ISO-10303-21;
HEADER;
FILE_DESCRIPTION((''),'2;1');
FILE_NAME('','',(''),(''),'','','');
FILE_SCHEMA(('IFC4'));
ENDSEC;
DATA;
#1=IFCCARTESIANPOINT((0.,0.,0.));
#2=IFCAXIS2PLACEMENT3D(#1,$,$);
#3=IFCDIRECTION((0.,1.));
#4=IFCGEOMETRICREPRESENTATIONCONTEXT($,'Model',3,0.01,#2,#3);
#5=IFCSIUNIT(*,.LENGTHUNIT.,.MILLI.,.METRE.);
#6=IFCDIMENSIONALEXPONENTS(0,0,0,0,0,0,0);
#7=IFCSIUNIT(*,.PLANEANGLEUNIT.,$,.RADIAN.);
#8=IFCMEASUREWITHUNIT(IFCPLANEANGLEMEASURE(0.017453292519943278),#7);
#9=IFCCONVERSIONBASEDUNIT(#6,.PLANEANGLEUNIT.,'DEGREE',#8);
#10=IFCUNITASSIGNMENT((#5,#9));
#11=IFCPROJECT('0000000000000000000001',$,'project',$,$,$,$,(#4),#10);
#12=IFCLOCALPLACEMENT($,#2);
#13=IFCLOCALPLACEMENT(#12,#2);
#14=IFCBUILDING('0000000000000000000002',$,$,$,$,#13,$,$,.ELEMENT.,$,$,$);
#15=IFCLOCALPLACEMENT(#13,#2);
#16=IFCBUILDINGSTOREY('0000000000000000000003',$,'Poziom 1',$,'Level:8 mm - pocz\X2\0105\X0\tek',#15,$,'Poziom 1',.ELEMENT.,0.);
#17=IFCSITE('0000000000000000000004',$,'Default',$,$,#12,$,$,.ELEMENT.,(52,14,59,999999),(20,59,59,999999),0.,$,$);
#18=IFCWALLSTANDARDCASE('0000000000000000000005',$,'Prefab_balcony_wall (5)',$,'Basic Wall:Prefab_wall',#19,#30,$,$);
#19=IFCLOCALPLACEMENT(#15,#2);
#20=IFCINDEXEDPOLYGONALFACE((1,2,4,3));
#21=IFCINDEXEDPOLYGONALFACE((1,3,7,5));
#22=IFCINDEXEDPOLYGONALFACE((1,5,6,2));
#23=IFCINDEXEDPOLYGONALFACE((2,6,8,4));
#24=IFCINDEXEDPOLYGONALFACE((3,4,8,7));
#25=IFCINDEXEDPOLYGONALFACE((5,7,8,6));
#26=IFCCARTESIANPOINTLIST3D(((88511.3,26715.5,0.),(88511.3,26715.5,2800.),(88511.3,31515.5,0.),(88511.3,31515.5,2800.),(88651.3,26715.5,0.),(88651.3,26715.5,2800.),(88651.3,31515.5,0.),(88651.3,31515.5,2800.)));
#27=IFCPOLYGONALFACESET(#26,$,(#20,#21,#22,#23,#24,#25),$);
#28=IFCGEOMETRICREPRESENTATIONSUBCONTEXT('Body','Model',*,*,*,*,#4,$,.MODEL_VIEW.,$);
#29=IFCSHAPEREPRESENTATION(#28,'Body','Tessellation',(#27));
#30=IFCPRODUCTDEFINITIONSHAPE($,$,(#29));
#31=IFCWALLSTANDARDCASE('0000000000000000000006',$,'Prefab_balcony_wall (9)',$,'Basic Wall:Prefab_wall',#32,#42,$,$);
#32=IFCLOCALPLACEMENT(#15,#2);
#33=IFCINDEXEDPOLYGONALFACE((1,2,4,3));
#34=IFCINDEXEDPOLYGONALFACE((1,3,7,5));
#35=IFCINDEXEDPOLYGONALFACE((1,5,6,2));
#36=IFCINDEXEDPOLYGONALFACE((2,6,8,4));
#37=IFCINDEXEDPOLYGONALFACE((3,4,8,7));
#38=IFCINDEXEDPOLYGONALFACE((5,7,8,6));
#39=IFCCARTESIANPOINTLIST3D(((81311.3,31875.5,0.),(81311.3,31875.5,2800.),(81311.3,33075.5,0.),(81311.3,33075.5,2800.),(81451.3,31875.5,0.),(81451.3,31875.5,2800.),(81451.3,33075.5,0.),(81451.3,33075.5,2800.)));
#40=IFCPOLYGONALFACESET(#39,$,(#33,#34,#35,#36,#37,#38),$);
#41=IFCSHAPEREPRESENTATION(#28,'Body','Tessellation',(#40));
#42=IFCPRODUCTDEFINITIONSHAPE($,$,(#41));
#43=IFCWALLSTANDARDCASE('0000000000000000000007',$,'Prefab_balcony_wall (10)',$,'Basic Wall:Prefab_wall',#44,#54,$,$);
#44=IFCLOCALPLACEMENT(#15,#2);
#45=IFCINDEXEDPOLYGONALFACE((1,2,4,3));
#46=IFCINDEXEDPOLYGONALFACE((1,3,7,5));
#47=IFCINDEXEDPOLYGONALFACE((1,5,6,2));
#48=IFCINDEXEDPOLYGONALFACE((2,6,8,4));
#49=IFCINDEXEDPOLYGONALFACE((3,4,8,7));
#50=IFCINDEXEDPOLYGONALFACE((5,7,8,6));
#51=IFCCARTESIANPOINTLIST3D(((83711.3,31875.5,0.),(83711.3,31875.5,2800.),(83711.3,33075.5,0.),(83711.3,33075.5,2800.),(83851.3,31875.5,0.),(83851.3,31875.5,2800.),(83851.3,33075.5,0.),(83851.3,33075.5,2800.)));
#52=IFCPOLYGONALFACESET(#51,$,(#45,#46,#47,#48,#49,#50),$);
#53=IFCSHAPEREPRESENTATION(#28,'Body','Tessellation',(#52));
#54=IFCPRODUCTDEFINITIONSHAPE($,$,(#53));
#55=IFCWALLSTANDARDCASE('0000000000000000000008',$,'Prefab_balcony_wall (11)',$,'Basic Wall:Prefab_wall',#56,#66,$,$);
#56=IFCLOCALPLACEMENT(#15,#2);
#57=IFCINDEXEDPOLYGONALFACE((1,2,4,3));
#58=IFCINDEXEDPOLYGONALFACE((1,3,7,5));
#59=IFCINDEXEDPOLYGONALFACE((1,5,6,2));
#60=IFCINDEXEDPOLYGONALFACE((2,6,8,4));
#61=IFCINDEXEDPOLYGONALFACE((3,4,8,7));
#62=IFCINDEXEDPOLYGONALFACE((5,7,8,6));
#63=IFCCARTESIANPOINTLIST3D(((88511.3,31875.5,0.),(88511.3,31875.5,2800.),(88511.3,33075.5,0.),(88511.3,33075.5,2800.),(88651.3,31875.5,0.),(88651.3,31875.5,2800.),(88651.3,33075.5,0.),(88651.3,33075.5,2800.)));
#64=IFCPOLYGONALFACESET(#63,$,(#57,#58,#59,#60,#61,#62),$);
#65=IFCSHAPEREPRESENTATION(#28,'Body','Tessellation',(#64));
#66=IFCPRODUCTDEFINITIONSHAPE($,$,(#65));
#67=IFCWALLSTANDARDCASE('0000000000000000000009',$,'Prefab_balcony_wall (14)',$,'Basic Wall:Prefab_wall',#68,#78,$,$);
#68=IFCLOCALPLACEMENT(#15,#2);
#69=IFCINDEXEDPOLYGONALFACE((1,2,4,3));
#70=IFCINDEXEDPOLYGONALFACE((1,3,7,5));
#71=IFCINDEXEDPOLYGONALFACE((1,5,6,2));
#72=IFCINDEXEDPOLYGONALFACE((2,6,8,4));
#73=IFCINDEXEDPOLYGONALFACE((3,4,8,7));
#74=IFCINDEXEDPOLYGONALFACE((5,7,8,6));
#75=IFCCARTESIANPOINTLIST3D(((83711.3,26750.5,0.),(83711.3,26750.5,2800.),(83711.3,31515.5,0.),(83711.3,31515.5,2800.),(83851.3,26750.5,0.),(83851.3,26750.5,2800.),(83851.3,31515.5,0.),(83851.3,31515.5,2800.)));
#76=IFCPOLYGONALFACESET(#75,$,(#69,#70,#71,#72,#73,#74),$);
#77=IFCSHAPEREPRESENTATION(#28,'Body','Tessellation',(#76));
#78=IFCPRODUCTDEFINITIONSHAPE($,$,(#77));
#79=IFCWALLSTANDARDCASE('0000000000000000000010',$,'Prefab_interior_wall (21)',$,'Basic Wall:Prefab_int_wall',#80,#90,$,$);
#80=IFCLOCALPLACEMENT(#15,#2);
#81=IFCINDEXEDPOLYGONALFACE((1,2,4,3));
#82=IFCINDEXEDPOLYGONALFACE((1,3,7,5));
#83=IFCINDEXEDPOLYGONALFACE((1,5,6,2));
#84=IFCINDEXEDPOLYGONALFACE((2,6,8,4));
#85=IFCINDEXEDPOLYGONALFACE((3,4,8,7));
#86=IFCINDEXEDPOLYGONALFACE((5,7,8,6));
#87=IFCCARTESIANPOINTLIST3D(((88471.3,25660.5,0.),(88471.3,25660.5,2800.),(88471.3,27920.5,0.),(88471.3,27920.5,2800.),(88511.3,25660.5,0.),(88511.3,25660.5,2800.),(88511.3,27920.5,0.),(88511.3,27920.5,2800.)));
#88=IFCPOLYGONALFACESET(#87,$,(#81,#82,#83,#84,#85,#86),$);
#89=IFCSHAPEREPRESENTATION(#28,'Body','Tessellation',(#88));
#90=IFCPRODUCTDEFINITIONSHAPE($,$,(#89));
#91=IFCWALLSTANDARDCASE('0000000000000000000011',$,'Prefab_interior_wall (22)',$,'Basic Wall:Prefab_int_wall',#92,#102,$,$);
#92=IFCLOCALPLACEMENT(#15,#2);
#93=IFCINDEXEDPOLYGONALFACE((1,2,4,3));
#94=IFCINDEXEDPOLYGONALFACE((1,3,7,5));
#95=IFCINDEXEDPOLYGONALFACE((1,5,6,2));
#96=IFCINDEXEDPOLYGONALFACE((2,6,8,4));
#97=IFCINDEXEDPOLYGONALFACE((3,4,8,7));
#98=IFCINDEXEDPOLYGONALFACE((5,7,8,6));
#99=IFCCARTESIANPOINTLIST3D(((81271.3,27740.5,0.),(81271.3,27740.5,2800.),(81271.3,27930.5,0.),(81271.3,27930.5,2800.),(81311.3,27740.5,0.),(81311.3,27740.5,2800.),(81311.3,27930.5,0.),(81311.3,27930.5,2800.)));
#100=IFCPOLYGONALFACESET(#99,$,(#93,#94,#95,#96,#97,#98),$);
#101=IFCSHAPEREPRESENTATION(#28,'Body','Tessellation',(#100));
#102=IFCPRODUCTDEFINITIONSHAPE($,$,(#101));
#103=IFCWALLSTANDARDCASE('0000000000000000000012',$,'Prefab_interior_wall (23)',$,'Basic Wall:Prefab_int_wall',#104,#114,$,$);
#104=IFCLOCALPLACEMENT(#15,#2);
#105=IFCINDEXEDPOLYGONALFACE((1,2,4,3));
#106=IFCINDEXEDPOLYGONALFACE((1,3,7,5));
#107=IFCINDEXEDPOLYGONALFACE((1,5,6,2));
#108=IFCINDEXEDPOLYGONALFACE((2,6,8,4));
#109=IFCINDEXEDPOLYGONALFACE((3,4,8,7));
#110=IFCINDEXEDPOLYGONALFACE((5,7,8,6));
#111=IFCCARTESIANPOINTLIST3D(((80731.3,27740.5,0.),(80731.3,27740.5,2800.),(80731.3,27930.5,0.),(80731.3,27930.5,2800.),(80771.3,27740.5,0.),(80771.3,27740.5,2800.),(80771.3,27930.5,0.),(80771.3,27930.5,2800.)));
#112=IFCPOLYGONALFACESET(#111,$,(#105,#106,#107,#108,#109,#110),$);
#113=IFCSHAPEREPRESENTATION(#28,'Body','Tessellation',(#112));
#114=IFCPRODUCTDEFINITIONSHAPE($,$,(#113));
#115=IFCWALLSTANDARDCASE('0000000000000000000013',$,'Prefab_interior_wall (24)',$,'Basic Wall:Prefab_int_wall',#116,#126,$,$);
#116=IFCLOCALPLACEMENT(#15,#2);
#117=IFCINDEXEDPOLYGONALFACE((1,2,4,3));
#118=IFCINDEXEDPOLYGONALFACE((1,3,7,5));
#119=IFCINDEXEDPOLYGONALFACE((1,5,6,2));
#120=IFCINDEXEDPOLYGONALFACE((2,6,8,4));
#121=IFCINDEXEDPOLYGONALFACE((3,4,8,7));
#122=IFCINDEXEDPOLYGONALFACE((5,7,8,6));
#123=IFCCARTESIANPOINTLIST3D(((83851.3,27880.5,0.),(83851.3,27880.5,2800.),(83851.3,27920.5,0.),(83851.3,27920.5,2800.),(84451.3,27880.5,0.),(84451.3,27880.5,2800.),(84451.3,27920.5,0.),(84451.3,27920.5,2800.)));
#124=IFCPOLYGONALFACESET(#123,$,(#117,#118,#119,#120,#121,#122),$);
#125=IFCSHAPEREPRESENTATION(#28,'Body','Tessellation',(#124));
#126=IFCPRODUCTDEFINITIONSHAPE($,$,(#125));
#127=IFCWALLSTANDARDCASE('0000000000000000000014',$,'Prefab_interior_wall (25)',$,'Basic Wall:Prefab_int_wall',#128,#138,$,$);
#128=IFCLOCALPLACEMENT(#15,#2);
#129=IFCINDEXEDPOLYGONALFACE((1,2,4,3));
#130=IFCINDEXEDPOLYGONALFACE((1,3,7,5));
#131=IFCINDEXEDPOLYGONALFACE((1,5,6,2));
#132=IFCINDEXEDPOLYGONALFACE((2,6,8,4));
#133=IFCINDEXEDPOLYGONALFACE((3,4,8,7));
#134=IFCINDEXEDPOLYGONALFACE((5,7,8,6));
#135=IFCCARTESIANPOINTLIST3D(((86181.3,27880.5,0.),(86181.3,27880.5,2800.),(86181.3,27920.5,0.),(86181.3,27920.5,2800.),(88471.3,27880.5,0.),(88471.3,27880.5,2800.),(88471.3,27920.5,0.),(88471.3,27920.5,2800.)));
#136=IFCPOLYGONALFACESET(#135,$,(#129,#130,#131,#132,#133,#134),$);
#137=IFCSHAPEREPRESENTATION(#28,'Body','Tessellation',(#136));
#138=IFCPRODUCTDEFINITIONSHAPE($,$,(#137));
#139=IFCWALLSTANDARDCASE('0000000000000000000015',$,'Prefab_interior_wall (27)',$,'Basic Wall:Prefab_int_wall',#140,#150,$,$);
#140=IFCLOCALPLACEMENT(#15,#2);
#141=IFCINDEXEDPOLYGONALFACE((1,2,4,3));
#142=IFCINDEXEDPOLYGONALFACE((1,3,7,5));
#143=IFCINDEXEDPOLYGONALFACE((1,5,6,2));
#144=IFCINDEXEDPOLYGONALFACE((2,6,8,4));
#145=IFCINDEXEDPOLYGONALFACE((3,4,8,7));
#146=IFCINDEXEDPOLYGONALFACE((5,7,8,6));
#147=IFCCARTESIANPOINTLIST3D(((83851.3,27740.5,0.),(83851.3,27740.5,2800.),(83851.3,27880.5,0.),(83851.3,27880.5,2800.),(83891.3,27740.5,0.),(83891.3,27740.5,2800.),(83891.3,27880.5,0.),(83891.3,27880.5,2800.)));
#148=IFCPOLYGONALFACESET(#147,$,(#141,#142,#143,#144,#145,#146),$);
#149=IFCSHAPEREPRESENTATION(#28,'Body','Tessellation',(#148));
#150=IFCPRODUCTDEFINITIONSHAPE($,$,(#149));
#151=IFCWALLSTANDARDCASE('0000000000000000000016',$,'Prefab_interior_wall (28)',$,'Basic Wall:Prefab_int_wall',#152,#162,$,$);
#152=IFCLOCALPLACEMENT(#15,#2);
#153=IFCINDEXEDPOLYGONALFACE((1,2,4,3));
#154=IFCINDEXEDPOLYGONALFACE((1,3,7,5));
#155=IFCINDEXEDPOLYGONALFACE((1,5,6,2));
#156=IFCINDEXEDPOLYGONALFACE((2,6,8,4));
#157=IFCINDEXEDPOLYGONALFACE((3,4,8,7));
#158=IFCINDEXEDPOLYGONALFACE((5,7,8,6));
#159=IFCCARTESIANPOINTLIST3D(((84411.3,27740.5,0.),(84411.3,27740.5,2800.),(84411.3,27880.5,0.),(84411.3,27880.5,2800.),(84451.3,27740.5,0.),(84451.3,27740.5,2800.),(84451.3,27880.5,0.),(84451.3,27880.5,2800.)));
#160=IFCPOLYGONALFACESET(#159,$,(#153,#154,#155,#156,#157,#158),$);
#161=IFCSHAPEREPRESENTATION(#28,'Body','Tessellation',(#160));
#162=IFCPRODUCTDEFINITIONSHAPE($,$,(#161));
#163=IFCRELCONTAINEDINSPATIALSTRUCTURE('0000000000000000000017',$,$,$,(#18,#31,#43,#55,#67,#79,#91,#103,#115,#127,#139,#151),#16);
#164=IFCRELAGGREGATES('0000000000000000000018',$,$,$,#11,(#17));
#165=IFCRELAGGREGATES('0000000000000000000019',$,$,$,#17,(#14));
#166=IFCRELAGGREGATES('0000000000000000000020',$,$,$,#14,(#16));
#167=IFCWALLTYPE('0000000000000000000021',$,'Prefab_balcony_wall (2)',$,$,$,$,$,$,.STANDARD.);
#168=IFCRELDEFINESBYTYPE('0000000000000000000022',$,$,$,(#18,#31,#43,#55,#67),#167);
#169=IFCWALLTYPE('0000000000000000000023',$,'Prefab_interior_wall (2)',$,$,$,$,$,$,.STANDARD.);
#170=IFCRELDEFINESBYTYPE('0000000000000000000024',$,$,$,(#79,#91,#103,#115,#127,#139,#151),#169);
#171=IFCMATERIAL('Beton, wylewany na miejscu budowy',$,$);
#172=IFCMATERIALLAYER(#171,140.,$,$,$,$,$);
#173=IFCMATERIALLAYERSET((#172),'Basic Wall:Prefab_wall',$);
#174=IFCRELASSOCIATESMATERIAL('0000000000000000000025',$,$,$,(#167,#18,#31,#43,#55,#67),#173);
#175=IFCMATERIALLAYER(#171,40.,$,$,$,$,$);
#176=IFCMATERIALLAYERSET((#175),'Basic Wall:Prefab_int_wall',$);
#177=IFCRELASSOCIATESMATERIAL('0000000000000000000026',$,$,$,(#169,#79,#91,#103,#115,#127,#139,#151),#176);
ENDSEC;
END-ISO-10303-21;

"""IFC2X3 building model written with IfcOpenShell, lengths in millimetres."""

from ifc_helpers import new_model, entity, si_unit, converted_unit, direction, frame, frame_2d, origin, place, context, subcontext, project, spatial, rectangle, extrude, material, layer, layer_set, layer_usage, type_object, element, save


model = new_model("IFC2X3")

# Units and contexts
model_context = context("Model", 3, precision=0.01, world=origin(), true_north=direction((0.0, 1.0)))
body_context = subcontext(model_context, "Body", "Model", "MODEL_VIEW")
ifc_project = project(units=[si_unit("LENGTHUNIT", "METRE", prefix="MILLI"), converted_unit("PLANEANGLEUNIT", "DEGREE", entity("IfcPlaneAngleMeasure", 0.017453292519943278), si_unit("PLANEANGLEUNIT", "RADIAN"), dimensions=[0, 0, 0, 0, 0, 0, 0])], contexts=[model_context])

# Site, building, storey
site_placement = place(None, origin())
site = spatial("IfcSite", under=ifc_project, at=site_placement, Name="Default", CompositionType="ELEMENT", RefLatitude=(52, 14, 59, 999999), RefLongitude=(20, 59, 59, 999999), RefElevation=0.0)
building_placement = place(site_placement, origin())
building = spatial("IfcBuilding", under=site, at=building_placement, CompositionType="ELEMENT")
storey_placement = place(building_placement, origin())
storey = spatial("IfcBuildingStorey", under=building, at=storey_placement, Name="Poziom 1", ObjectType="Level:8 mm - początek", LongName="Poziom 1", CompositionType="ELEMENT", Elevation=0.0)

# Walls
ifc_material = material(Name="Beton, wylewany na miejscu budowy")
ifc_layer_1 = layer(ifc_material, 140.0)
ifc_layer_set_1 = layer_set([ifc_layer_1], Name="Basic Wall:Prefab_wall")
ifc_layer_usage_1 = layer_usage(ifc_layer_set_1, "AXIS2", "NEGATIVE", 70.0)
wall_type_1 = type_object("IfcWallType", Name="Prefab_balcony_wall (2)", PredefinedType="STANDARD", material=ifc_layer_set_1)
wall_1_placement = place(storey_placement, frame((88581.3, 31515.5, 0.0), z_axis=(0.0, 0.0, 1.0), x_axis=(0.0, -1.0, 0.0)))
element("IfcWallStandardCase", 1, at=wall_1_placement, inside=storey, type_object=wall_type_1, material=ifc_layer_usage_1, Name="Prefab_balcony_wall (5)", ObjectType="Basic Wall:Prefab_wall", context=body_context, shape_type="SweptSolid", body=[
    extrude(rectangle(XDim=4800.0, YDim=140.0, at=frame_2d((2400.0, 0.0), x_axis=(-1.0, 0.0))), origin(), (0.0, 0.0, 1.0), 2800.0),
])
ifc_layer_usage_2 = layer_usage(ifc_layer_set_1, "AXIS2", "NEGATIVE", 70.0)
wall_2_placement = place(storey_placement, frame((81381.3, 33075.5, 0.0), z_axis=(0.0, 0.0, 1.0), x_axis=(0.0, -1.0, 0.0)))
element("IfcWallStandardCase", 2, at=wall_2_placement, inside=storey, type_object=wall_type_1, material=ifc_layer_usage_2, Name="Prefab_balcony_wall (9)", ObjectType="Basic Wall:Prefab_wall", context=body_context, shape_type="SweptSolid", body=[
    extrude(rectangle(XDim=1200.0, YDim=140.0, at=frame_2d((600.0, 0.0), x_axis=(-1.0, 0.0))), origin(), (0.0, 0.0, 1.0), 2800.0),
])
ifc_layer_usage_3 = layer_usage(ifc_layer_set_1, "AXIS2", "NEGATIVE", 70.0)
wall_3_placement = place(storey_placement, frame((83781.3, 33075.5, 0.0), z_axis=(0.0, 0.0, 1.0), x_axis=(0.0, -1.0, 0.0)))
element("IfcWallStandardCase", 3, at=wall_3_placement, inside=storey, type_object=wall_type_1, material=ifc_layer_usage_3, Name="Prefab_balcony_wall (10)", ObjectType="Basic Wall:Prefab_wall", context=body_context, shape_type="SweptSolid", body=[
    extrude(rectangle(XDim=1200.0, YDim=140.0, at=frame_2d((600.0, 0.0), x_axis=(-1.0, 0.0))), origin(), (0.0, 0.0, 1.0), 2800.0),
])
ifc_layer_usage_4 = layer_usage(ifc_layer_set_1, "AXIS2", "NEGATIVE", 70.0)
wall_4_placement = place(storey_placement, frame((88581.3, 33075.5, 0.0), z_axis=(0.0, 0.0, 1.0), x_axis=(0.0, -1.0, 0.0)))
element("IfcWallStandardCase", 4, at=wall_4_placement, inside=storey, type_object=wall_type_1, material=ifc_layer_usage_4, Name="Prefab_balcony_wall (11)", ObjectType="Basic Wall:Prefab_wall", context=body_context, shape_type="SweptSolid", body=[
    extrude(rectangle(XDim=1200.0, YDim=140.0, at=frame_2d((600.0, 0.0), x_axis=(-1.0, 0.0))), origin(), (0.0, 0.0, 1.0), 2800.0),
])
ifc_layer_usage_5 = layer_usage(ifc_layer_set_1, "AXIS2", "NEGATIVE", 70.0)
wall_5_placement = place(storey_placement, frame((83781.3, 26750.5, 0.0), z_axis=(0.0, 0.0, 1.0), x_axis=(0.0, 1.0, 0.0)))
element("IfcWallStandardCase", 5, at=wall_5_placement, inside=storey, type_object=wall_type_1, material=ifc_layer_usage_5, Name="Prefab_balcony_wall (14)", ObjectType="Basic Wall:Prefab_wall", context=body_context, shape_type="SweptSolid", body=[
    extrude(rectangle(XDim=4765.0, YDim=140.0, at=frame_2d((2382.5, 0.0), x_axis=(-1.0, 0.0))), origin(), (0.0, 0.0, 1.0), 2800.0),
])
ifc_layer_2 = layer(ifc_material, 40.0)
ifc_layer_set_2 = layer_set([ifc_layer_2], Name="Basic Wall:Prefab_int_wall")
ifc_layer_usage_6 = layer_usage(ifc_layer_set_2, "AXIS2", "NEGATIVE", 20.0)
wall_type_2 = type_object("IfcWallType", Name="Prefab_interior_wall (2)", PredefinedType="STANDARD", material=ifc_layer_set_2)
wall_6_placement = place(storey_placement, frame((88491.3, 27920.5, 0.0), z_axis=(0.0, 0.0, 1.0), x_axis=(0.0, -1.0, 0.0)))
element("IfcWallStandardCase", 6, at=wall_6_placement, inside=storey, type_object=wall_type_2, material=ifc_layer_usage_6, Name="Prefab_interior_wall (21)", ObjectType="Basic Wall:Prefab_int_wall", context=body_context, shape_type="SweptSolid", body=[
    extrude(rectangle(XDim=2260.0, YDim=40.0, at=frame_2d((1130.0, 0.0), x_axis=(-1.0, 0.0))), origin(), (0.0, 0.0, 1.0), 2800.0),
])
ifc_layer_usage_7 = layer_usage(ifc_layer_set_2, "AXIS2", "NEGATIVE", 20.0)
wall_7_placement = place(storey_placement, frame((81291.3, 27930.5, 0.0), z_axis=(0.0, 0.0, 1.0), x_axis=(0.0, -1.0, 0.0)))
element("IfcWallStandardCase", 7, at=wall_7_placement, inside=storey, type_object=wall_type_2, material=ifc_layer_usage_7, Name="Prefab_interior_wall (22)", ObjectType="Basic Wall:Prefab_int_wall", context=body_context, shape_type="SweptSolid", body=[
    extrude(rectangle(XDim=190.0, YDim=40.0, at=frame_2d((95.0, 0.0), x_axis=(-1.0, 0.0))), origin(), (0.0, 0.0, 1.0), 2800.0),
])
ifc_layer_usage_8 = layer_usage(ifc_layer_set_2, "AXIS2", "NEGATIVE", 20.0)
wall_8_placement = place(storey_placement, frame((80751.3, 27930.5, 0.0), z_axis=(0.0, 0.0, 1.0), x_axis=(0.0, -1.0, 0.0)))
element("IfcWallStandardCase", 8, at=wall_8_placement, inside=storey, type_object=wall_type_2, material=ifc_layer_usage_8, Name="Prefab_interior_wall (23)", ObjectType="Basic Wall:Prefab_int_wall", context=body_context, shape_type="SweptSolid", body=[
    extrude(rectangle(XDim=190.0, YDim=40.0, at=frame_2d((95.0, 0.0), x_axis=(-1.0, 0.0))), origin(), (0.0, 0.0, 1.0), 2800.0),
])
ifc_layer_usage_9 = layer_usage(ifc_layer_set_2, "AXIS2", "NEGATIVE", 20.0)
wall_9_placement = place(storey_placement, frame((84451.3, 27900.5, 0.0), z_axis=(0.0, 0.0, 1.0), x_axis=(-1.0, 0.0, 0.0)))
element("IfcWallStandardCase", 9, at=wall_9_placement, inside=storey, type_object=wall_type_2, material=ifc_layer_usage_9, Name="Prefab_interior_wall (24)", ObjectType="Basic Wall:Prefab_int_wall", context=body_context, shape_type="SweptSolid", body=[
    extrude(rectangle(XDim=600.0, YDim=40.0, at=frame_2d((300.0, 0.0), x_axis=(-1.0, 0.0))), origin(), (0.0, 0.0, 1.0), 2800.0),
])
ifc_layer_usage_10 = layer_usage(ifc_layer_set_2, "AXIS2", "NEGATIVE", 20.0)
wall_10_placement = place(storey_placement, frame((86181.3, 27900.5, 0.0)))
element("IfcWallStandardCase", 10, at=wall_10_placement, inside=storey, type_object=wall_type_2, material=ifc_layer_usage_10, Name="Prefab_interior_wall (25)", ObjectType="Basic Wall:Prefab_int_wall", context=body_context, shape_type="SweptSolid", body=[
    extrude(rectangle(XDim=2290.0, YDim=40.0, at=frame_2d((1145.0, 0.0), x_axis=(-1.0, 0.0))), origin(), (0.0, 0.0, 1.0), 2800.0),
])
ifc_layer_usage_11 = layer_usage(ifc_layer_set_2, "AXIS2", "NEGATIVE", 20.0)
wall_11_placement = place(storey_placement, frame((83871.3, 27880.5, 0.0), z_axis=(0.0, 0.0, 1.0), x_axis=(0.0, -1.0, 0.0)))
element("IfcWallStandardCase", 11, at=wall_11_placement, inside=storey, type_object=wall_type_2, material=ifc_layer_usage_11, Name="Prefab_interior_wall (27)", ObjectType="Basic Wall:Prefab_int_wall", context=body_context, shape_type="SweptSolid", body=[
    extrude(rectangle(XDim=140.0, YDim=40.0, at=frame_2d((70.0, 0.0), x_axis=(-1.0, 0.0))), origin(), (0.0, 0.0, 1.0), 2800.0),
])
ifc_layer_usage_12 = layer_usage(ifc_layer_set_2, "AXIS2", "NEGATIVE", 20.0)
wall_12_placement = place(storey_placement, frame((84431.3, 27880.5, 0.0), z_axis=(0.0, 0.0, 1.0), x_axis=(0.0, -1.0, 0.0)))
element("IfcWallStandardCase", 12, at=wall_12_placement, inside=storey, type_object=wall_type_2, material=ifc_layer_usage_12, Name="Prefab_interior_wall (28)", ObjectType="Basic Wall:Prefab_int_wall", context=body_context, shape_type="SweptSolid", body=[
    extrude(rectangle(XDim=140.0, YDim=40.0, at=frame_2d((70.0, 0.0), x_axis=(-1.0, 0.0))), origin(), (0.0, 0.0, 1.0), 2800.0),
])

save(model, "model.ifc")
